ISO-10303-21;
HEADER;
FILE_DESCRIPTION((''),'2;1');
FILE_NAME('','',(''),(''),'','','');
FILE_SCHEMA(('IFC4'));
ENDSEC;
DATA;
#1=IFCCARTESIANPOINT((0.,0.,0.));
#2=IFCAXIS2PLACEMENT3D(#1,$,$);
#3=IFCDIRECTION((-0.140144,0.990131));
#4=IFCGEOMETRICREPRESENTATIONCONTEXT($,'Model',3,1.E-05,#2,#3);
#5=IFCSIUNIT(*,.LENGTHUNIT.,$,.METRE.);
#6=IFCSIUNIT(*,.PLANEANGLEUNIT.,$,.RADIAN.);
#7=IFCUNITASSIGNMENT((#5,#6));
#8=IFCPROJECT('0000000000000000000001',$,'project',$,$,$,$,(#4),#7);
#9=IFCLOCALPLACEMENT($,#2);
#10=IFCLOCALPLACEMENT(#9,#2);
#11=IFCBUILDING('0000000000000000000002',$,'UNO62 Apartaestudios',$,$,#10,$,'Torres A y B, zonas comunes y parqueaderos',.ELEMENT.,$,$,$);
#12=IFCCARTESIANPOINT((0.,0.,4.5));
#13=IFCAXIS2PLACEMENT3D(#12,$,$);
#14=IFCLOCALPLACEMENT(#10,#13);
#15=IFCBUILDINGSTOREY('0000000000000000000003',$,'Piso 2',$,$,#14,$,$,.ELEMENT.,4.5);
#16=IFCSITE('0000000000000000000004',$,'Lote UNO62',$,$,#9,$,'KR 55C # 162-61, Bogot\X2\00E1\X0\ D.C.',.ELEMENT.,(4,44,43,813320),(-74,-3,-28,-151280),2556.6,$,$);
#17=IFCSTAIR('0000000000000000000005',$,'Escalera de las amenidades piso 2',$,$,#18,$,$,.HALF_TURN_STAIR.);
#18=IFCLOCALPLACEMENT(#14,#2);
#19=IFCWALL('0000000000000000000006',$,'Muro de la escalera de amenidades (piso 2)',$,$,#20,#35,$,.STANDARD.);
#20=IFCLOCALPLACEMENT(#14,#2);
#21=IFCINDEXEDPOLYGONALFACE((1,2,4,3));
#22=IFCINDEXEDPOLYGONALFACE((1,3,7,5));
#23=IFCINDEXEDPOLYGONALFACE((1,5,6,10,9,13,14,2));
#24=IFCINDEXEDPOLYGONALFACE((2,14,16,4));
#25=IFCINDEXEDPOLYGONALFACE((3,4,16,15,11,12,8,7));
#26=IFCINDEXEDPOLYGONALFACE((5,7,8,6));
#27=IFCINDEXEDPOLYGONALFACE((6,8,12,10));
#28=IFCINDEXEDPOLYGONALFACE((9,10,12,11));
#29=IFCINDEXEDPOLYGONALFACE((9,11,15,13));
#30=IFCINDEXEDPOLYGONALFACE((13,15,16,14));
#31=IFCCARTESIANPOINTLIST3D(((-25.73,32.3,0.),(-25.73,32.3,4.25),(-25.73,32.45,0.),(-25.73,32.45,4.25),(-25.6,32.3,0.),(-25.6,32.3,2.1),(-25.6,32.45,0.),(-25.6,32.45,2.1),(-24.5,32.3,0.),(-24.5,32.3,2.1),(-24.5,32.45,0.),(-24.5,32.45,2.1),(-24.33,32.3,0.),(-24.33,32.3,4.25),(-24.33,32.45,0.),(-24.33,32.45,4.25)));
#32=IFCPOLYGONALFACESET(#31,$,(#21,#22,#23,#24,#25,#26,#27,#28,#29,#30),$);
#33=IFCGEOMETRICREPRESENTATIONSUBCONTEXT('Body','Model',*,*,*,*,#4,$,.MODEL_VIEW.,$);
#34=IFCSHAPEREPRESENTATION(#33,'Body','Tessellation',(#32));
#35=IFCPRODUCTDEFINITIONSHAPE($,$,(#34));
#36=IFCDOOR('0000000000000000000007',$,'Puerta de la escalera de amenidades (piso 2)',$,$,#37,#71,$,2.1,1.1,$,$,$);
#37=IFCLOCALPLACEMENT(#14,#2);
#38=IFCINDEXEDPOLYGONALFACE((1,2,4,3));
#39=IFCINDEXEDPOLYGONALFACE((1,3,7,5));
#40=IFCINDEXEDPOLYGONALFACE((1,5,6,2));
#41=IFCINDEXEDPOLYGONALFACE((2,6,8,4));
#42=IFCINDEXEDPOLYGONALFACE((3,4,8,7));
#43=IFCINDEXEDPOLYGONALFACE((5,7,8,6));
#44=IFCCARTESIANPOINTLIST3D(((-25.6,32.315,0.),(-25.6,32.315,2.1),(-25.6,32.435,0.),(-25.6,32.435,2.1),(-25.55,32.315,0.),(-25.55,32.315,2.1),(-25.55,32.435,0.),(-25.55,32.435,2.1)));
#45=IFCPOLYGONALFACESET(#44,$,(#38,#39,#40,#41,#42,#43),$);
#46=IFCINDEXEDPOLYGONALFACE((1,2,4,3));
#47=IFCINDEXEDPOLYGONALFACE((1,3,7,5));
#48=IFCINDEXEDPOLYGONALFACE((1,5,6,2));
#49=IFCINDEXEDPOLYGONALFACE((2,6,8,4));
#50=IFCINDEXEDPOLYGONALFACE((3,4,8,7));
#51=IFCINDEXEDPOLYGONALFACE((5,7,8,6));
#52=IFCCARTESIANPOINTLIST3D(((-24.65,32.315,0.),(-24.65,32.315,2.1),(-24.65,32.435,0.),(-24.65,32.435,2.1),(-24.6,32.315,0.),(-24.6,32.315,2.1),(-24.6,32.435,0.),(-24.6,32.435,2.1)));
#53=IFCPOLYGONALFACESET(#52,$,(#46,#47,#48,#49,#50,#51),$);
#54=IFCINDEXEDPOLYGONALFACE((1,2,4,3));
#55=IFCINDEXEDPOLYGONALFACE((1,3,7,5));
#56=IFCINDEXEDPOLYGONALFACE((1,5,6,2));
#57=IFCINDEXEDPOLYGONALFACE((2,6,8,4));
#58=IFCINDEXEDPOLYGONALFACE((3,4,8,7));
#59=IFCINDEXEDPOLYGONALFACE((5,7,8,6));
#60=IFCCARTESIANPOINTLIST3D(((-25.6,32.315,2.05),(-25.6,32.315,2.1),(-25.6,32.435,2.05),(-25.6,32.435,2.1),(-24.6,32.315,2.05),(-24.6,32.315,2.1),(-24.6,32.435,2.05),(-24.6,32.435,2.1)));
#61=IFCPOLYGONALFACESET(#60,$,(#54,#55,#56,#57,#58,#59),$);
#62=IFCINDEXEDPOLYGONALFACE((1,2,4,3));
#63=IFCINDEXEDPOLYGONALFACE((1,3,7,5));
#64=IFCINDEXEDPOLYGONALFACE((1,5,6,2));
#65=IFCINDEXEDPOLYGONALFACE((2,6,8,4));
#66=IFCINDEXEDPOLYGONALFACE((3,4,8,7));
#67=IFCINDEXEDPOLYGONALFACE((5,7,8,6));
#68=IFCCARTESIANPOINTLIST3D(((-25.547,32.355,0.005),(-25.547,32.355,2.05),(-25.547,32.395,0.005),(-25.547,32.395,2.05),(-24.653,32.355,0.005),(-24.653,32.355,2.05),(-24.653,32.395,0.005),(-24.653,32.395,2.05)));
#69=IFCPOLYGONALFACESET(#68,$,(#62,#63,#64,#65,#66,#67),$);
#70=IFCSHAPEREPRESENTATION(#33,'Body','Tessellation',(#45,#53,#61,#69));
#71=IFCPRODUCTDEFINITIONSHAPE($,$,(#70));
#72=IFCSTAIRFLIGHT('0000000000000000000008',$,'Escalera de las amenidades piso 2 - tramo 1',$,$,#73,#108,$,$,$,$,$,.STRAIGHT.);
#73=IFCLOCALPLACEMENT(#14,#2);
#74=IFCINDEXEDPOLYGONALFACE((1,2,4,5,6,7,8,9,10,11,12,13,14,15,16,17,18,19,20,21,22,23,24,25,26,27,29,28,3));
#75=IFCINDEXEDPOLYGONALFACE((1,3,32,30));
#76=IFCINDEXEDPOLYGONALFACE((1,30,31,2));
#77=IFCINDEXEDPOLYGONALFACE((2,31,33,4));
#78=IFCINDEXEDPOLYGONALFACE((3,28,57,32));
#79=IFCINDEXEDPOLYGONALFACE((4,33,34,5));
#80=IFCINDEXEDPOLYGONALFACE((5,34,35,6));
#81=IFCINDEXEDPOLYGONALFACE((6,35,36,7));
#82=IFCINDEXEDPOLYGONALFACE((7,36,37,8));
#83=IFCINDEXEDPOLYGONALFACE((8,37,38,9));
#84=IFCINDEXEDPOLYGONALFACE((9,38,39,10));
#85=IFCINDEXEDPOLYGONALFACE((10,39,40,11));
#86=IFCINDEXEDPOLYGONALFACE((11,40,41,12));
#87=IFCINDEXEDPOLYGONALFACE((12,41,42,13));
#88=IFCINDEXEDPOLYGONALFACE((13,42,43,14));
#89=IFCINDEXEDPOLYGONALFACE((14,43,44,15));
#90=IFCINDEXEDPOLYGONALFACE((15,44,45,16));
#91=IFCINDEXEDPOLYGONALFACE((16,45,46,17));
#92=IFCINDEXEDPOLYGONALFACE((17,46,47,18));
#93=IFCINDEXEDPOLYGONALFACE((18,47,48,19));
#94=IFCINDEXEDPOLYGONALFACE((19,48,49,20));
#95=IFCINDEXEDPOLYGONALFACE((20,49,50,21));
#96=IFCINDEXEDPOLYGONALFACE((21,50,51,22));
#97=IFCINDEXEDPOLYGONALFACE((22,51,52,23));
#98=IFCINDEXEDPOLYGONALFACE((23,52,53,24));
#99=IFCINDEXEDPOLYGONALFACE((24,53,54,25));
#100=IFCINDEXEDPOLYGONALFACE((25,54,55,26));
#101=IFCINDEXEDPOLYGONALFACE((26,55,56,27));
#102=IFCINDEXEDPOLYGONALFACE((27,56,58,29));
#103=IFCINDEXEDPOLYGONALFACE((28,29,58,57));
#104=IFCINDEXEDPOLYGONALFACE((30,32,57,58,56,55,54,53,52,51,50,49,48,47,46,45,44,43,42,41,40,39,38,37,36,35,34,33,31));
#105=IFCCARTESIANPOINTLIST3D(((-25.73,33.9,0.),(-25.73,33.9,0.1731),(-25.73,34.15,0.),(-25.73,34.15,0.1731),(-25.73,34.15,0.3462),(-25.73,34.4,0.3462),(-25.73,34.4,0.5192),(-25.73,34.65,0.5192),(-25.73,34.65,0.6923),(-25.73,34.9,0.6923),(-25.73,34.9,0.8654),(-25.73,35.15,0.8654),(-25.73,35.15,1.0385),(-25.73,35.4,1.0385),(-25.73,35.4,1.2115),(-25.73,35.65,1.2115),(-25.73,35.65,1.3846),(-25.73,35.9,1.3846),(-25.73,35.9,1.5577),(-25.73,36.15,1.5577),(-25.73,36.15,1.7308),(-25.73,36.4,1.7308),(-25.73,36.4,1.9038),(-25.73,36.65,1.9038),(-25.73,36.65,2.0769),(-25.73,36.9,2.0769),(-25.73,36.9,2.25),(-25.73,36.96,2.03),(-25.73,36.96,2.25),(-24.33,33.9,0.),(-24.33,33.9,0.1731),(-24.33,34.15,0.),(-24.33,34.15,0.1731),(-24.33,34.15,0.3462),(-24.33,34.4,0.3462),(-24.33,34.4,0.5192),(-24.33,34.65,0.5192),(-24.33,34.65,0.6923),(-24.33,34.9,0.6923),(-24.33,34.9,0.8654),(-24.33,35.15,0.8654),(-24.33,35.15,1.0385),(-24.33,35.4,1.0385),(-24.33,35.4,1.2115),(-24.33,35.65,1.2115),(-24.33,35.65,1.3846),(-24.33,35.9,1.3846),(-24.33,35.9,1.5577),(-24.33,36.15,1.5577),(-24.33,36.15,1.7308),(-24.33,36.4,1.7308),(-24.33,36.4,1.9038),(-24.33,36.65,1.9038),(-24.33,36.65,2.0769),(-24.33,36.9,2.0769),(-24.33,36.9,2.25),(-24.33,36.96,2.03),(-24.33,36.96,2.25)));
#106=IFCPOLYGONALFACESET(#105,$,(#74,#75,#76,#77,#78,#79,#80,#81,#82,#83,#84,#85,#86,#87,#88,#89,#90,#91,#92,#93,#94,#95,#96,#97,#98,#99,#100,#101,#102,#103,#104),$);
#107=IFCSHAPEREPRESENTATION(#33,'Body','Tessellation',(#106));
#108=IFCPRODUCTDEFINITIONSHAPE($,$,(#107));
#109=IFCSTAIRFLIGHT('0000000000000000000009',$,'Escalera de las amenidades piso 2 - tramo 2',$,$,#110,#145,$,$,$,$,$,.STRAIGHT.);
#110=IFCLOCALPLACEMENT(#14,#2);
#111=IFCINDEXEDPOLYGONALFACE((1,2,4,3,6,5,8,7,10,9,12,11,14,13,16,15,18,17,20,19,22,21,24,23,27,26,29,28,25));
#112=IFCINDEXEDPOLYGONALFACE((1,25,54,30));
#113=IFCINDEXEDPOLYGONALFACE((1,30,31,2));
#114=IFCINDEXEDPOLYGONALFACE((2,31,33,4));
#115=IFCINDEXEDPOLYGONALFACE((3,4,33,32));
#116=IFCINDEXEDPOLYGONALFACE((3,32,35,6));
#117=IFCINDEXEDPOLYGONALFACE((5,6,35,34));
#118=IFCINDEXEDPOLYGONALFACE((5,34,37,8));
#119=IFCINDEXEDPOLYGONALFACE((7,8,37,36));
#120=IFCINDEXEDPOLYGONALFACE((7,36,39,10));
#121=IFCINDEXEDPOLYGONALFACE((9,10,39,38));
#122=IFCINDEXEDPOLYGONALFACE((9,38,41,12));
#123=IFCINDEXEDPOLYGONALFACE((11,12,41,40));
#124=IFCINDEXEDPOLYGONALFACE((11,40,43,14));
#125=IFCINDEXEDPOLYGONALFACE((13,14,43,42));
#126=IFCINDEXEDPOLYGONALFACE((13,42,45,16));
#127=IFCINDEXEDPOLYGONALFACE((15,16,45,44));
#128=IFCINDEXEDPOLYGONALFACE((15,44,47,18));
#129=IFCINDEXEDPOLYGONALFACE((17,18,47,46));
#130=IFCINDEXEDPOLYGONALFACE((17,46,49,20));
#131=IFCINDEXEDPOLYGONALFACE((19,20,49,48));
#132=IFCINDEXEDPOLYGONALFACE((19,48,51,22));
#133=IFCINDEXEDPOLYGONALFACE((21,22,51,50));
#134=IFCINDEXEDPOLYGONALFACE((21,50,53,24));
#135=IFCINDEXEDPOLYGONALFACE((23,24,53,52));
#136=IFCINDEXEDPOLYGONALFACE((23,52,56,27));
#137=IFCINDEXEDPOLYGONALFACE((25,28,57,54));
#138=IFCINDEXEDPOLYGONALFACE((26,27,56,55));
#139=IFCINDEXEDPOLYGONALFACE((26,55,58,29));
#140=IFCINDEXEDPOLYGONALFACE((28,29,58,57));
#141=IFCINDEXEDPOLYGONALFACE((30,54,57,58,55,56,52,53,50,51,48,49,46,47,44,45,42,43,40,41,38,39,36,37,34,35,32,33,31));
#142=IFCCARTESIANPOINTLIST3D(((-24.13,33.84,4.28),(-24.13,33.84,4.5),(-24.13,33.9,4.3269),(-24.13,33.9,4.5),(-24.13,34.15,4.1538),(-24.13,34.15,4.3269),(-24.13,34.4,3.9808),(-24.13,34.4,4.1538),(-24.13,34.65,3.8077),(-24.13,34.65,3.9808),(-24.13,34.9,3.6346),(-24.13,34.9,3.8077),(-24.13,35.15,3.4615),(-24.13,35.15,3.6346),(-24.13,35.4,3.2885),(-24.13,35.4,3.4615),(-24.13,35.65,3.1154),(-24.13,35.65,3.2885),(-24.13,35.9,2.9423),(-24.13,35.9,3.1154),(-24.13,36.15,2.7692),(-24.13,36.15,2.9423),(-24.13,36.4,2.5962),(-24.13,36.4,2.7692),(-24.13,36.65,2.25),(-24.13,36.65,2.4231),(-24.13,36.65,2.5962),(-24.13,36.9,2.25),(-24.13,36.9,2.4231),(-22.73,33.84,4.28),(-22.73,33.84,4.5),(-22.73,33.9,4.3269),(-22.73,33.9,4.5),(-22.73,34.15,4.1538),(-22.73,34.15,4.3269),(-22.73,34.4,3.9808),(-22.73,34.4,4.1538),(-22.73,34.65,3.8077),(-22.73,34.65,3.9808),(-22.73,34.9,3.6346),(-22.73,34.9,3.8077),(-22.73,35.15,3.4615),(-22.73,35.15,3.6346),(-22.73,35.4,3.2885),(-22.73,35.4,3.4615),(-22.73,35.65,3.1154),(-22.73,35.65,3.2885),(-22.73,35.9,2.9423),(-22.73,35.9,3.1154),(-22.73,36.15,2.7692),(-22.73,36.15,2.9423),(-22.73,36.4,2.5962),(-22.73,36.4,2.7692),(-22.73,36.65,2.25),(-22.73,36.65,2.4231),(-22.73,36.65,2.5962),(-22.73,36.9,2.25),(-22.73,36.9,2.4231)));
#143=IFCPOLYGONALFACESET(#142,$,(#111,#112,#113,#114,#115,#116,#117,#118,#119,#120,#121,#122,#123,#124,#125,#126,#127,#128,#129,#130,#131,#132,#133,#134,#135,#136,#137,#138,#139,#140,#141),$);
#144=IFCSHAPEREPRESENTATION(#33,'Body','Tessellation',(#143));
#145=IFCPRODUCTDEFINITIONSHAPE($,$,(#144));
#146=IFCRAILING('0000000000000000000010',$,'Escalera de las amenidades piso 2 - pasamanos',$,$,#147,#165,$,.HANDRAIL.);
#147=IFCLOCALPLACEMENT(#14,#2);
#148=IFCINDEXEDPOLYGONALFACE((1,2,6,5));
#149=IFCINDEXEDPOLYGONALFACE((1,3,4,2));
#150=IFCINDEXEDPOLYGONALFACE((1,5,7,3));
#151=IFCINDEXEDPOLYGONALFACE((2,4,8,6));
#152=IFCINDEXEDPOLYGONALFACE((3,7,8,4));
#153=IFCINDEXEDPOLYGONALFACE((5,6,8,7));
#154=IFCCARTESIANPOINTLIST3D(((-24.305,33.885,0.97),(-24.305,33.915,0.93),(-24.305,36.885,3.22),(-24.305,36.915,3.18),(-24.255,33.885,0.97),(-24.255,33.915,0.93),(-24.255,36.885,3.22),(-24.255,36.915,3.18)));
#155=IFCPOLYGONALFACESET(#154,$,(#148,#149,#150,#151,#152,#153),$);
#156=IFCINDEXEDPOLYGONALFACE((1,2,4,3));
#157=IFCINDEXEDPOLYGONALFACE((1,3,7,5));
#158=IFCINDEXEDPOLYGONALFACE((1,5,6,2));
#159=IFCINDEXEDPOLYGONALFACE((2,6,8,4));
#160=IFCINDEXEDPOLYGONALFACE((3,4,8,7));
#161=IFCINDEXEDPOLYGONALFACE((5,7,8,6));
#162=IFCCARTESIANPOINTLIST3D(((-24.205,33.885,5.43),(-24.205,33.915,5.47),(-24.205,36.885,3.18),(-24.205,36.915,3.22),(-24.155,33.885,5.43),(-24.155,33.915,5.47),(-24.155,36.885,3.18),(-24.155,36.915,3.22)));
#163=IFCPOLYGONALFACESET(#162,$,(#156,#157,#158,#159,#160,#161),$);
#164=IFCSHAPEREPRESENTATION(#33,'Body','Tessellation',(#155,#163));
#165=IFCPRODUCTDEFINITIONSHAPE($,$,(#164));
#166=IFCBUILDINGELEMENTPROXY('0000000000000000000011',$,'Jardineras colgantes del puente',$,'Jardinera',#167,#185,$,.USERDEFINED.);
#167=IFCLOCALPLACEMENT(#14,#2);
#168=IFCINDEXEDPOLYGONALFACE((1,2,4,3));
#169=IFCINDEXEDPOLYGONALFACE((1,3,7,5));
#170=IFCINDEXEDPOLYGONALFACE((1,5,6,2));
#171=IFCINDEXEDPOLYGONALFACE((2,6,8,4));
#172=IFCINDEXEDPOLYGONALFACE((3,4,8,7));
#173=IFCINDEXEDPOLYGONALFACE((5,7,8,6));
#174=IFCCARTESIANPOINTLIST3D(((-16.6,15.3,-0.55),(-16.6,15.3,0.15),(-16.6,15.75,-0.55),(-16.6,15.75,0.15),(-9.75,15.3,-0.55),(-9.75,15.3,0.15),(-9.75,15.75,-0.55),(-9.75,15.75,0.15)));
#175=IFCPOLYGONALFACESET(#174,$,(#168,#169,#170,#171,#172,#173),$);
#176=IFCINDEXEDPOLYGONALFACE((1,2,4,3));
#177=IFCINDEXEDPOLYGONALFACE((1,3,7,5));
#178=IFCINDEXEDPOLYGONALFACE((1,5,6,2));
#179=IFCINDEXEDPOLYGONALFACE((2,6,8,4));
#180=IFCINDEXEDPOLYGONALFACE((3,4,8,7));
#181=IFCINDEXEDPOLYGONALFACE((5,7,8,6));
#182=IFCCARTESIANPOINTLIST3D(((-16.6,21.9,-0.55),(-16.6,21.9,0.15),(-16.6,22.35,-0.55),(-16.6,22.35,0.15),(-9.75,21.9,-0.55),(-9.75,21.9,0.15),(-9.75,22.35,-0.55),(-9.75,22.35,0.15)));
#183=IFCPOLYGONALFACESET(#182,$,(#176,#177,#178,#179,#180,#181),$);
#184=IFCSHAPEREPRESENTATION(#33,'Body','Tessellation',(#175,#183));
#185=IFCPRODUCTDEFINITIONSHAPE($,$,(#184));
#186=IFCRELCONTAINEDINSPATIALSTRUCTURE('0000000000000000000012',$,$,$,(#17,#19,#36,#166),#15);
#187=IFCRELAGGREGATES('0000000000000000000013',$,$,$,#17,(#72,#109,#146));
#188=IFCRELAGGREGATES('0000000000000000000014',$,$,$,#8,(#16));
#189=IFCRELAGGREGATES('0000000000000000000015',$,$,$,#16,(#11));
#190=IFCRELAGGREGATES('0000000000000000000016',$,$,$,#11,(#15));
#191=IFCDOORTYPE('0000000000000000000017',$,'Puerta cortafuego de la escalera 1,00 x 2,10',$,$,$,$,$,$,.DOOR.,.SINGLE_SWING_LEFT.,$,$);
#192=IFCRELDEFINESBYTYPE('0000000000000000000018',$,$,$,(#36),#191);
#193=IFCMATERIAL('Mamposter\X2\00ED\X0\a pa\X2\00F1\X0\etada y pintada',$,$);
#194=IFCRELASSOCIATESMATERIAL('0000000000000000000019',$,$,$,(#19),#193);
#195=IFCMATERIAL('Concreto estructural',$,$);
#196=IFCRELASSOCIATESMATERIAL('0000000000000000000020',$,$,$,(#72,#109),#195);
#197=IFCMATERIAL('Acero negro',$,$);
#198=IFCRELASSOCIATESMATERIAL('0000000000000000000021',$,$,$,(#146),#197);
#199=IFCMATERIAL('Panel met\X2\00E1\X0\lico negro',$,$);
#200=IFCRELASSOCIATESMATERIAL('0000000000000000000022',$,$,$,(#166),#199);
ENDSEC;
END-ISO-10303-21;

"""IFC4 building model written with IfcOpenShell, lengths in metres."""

from ifc_helpers import new_model, si_unit, direction, frame, frame_2d, origin, origin_2d, place, context, subcontext, project, spatial, polyline, rectangle, outline, extrude, source, transform, mapped, material, type_object, type_shapes, element, fill, aggregate, save


model = new_model("IFC4")

# Units and contexts
model_context = context("Model", 3, precision=1e-05, world=origin(), true_north=direction((-0.140144, 0.990131)))
body_context = subcontext(model_context, "Body", "Model", "MODEL_VIEW")
ifc_project = project(units=[si_unit("LENGTHUNIT", "METRE"), si_unit("PLANEANGLEUNIT", "RADIAN")], contexts=[model_context])

# Site, building, storey
site_placement = place(None, origin())
site = spatial("IfcSite", under=ifc_project, at=site_placement, Name="Lote UNO62", LongName="KR 55C # 162-61, Bogotá D.C.", CompositionType="ELEMENT", RefLatitude=(4, 44, 43, 813320), RefLongitude=(-74, -3, -28, -151280), RefElevation=2556.6)
building_placement = place(site_placement, origin())
building = spatial("IfcBuilding", under=site, at=building_placement, Name="UNO62 Apartaestudios", LongName="Torres A y B, zonas comunes y parqueaderos", CompositionType="ELEMENT")
storey_placement = place(building_placement, frame((0.0, 0.0, 4.5)))
storey = spatial("IfcBuildingStorey", under=building, at=storey_placement, Name="Piso 2", CompositionType="ELEMENT", Elevation=4.5)

# Shared definitions
ifc_material_1 = material(Name="Concreto estructural")

# Stair
stair_placement = place(storey_placement, origin())
stair = element("IfcStair", 1, at=stair_placement, inside=storey, Name="Escalera de las amenidades piso 2", PredefinedType="HALF_TURN_STAIR")

# Shared definitions
ifc_material_2 = material(Name="Panel metálico negro")

# Shared definitions
ifc_material_3 = material(Name="Mampostería pañetada y pintada")

# Wall, opening, door
wall_1_placement = place(storey_placement, origin())
wall_1 = element("IfcWall", 2, at=wall_1_placement, inside=storey, material=ifc_material_3, Name="Muro de la escalera de amenidades (piso 2)", PredefinedType="STANDARD", context=body_context, shape_type="SweptSolid", body=[
    extrude(rectangle(XDim=1.4, YDim=0.15, at=frame_2d((-25.03, 32.375))), origin(), (0.0, 0.0, 1.0), 4.25),
])
opening_1_placement = place(wall_1_placement, origin())
opening_1 = element("IfcOpeningElement", 3, at=opening_1_placement, cuts=wall_1, PredefinedType="OPENING", context=body_context, shape_type="SweptSolid", body=[
    extrude(rectangle(XDim=1.1, YDim=0.25, at=frame_2d((-25.05, 32.375))), origin(), (0.0, 0.0, 1.0), 2.1),
])
door_type_1 = type_object("IfcDoorType", Name="Puerta cortafuego de la escalera 1,00 x 2,10", OperationType="SINGLE_SWING_LEFT", PredefinedType="DOOR")
shared_shape_1 = source(origin(), body_context, "Body", "SweptSolid", [
    extrude(rectangle(XDim=0.05, YDim=0.12, at=frame_2d((0.025, 0.0))), origin(), (0.0, 0.0, 1.0), 2.1),
    extrude(rectangle(XDim=0.05, YDim=0.12, at=frame_2d((0.975, 0.0))), origin(), (0.0, 0.0, 1.0), 2.1),
    extrude(rectangle(XDim=1.0, YDim=0.12, at=frame_2d((0.5, 0.0))), frame((0.0, 0.0, 2.05)), (0.0, 0.0, 1.0), 0.05),
    extrude(rectangle(XDim=0.894, YDim=0.04, at=frame_2d((0.5, 0.0))), frame((0.0, 0.0, 0.005)), (0.0, 0.0, 1.0), 2.045),
])
type_shapes(door_type_1, [shared_shape_1])
door_1_placement = place(storey_placement, frame((-25.6, 32.375, 0.0), z_axis=(0.0, 0.0, 1.0), x_axis=(1.0, 0.0, 0.0)))
door_1 = element("IfcDoor", 4, at=door_1_placement, inside=storey, type_object=door_type_1, Name="Puerta de la escalera de amenidades (piso 2)", OverallHeight=2.1, OverallWidth=1.1, context=body_context, shape_type="MappedRepresentation", body=[
    mapped(shared_shape_1, transform((0.0, 0.0, 0.0))),
])
fill(opening_1, door_1)

# Stair flights
stair_flight_1_placement = place(storey_placement, origin())
stair_flight_1 = element("IfcStairFlight", 5, at=stair_flight_1_placement, material=ifc_material_1, Name="Escalera de las amenidades piso 2 - tramo 1", PredefinedType="STRAIGHT", context=body_context, shape_type="SweptSolid", body=[
    extrude(outline(polyline([(0.0, 0.0), (0.0, 0.1731), (0.25, 0.1731), (0.25, 0.3462), (0.5, 0.3462), (0.5, 0.5192), (0.75, 0.5192), (0.75, 0.6923), (1.0, 0.6923), (1.0, 0.8654), (1.25, 0.8654), (1.25, 1.0385), (1.5, 1.0385), (1.5, 1.2115), (1.75, 1.2115), (1.75, 1.3846), (2.0, 1.3846), (2.0, 1.5577), (2.25, 1.5577), (2.25, 1.7308), (2.5, 1.7308), (2.5, 1.9038), (2.75, 1.9038), (2.75, 2.0769), (3.0, 2.0769), (3.0, 2.25), (3.06, 2.25), (3.06, 2.03), (0.25, 0.0), (0.0, 0.0)])), frame((-25.73, 33.9, 0.0), z_axis=(1.0, 0.0, 0.0), x_axis=(0.0, 1.0, 0.0)), (0.0, 0.0, 1.0), 1.4),
])
stair_flight_2_placement = place(storey_placement, origin())
stair_flight_2 = element("IfcStairFlight", 6, at=stair_flight_2_placement, material=ifc_material_1, Name="Escalera de las amenidades piso 2 - tramo 2", PredefinedType="STRAIGHT", context=body_context, shape_type="SweptSolid", body=[
    extrude(outline(polyline([(0.0, 0.0), (0.0, 0.1731), (0.25, 0.1731), (0.25, 0.3462), (0.5, 0.3462), (0.5, 0.5192), (0.75, 0.5192), (0.75, 0.6923), (1.0, 0.6923), (1.0, 0.8654), (1.25, 0.8654), (1.25, 1.0385), (1.5, 1.0385), (1.5, 1.2115), (1.75, 1.2115), (1.75, 1.3846), (2.0, 1.3846), (2.0, 1.5577), (2.25, 1.5577), (2.25, 1.7308), (2.5, 1.7308), (2.5, 1.9038), (2.75, 1.9038), (2.75, 2.0769), (3.0, 2.0769), (3.0, 2.25), (3.06, 2.25), (3.06, 2.03), (0.25, 0.0), (0.0, 0.0)])), frame((-22.73, 36.9, 2.25), z_axis=(-1.0, 0.0, 0.0), x_axis=(0.0, -1.0, 0.0)), (0.0, 0.0, 1.0), 1.4),
])

# Railing
ifc_material_4 = material(Name="Acero negro")
railing_placement = place(storey_placement, origin())
railing = element("IfcRailing", 7, at=railing_placement, material=ifc_material_4, Name="Escalera de las amenidades piso 2 - pasamanos", PredefinedType="HANDRAIL", context=body_context, shape_type="SweptSolid", body=[
    extrude(rectangle(XDim=0.05, YDim=0.05, at=origin_2d()), frame((-24.28, 33.9, 0.95), z_axis=(0.0, 0.8, 0.6), x_axis=(1.0, 0.0, 0.0)), (0.0, 0.0, 1.0), 3.75),
    extrude(rectangle(XDim=0.05, YDim=0.05, at=origin_2d()), frame((-24.18, 36.9, 3.2), z_axis=(0.0, -0.8, 0.6), x_axis=(-1.0, 0.0, 0.0)), (0.0, 0.0, 1.0), 3.75),
])
aggregate(stair, [stair_flight_1, stair_flight_2, railing])

# Building element proxy
proxy_placement = place(storey_placement, origin())
element("IfcBuildingElementProxy", 8, at=proxy_placement, inside=storey, material=ifc_material_2, Name="Jardineras colgantes del puente", ObjectType="Jardinera", PredefinedType="USERDEFINED", context=body_context, shape_type="SweptSolid", body=[
    extrude(rectangle(XDim=6.85, YDim=0.45, at=frame_2d((-13.175, 15.525))), frame((0.0, 0.0, -0.55)), (0.0, 0.0, 1.0), 0.7),
    extrude(rectangle(XDim=6.85, YDim=0.45, at=frame_2d((-13.175, 22.125))), frame((0.0, 0.0, -0.55)), (0.0, 0.0, 1.0), 0.7),
])

save(model, "model.ifc")
